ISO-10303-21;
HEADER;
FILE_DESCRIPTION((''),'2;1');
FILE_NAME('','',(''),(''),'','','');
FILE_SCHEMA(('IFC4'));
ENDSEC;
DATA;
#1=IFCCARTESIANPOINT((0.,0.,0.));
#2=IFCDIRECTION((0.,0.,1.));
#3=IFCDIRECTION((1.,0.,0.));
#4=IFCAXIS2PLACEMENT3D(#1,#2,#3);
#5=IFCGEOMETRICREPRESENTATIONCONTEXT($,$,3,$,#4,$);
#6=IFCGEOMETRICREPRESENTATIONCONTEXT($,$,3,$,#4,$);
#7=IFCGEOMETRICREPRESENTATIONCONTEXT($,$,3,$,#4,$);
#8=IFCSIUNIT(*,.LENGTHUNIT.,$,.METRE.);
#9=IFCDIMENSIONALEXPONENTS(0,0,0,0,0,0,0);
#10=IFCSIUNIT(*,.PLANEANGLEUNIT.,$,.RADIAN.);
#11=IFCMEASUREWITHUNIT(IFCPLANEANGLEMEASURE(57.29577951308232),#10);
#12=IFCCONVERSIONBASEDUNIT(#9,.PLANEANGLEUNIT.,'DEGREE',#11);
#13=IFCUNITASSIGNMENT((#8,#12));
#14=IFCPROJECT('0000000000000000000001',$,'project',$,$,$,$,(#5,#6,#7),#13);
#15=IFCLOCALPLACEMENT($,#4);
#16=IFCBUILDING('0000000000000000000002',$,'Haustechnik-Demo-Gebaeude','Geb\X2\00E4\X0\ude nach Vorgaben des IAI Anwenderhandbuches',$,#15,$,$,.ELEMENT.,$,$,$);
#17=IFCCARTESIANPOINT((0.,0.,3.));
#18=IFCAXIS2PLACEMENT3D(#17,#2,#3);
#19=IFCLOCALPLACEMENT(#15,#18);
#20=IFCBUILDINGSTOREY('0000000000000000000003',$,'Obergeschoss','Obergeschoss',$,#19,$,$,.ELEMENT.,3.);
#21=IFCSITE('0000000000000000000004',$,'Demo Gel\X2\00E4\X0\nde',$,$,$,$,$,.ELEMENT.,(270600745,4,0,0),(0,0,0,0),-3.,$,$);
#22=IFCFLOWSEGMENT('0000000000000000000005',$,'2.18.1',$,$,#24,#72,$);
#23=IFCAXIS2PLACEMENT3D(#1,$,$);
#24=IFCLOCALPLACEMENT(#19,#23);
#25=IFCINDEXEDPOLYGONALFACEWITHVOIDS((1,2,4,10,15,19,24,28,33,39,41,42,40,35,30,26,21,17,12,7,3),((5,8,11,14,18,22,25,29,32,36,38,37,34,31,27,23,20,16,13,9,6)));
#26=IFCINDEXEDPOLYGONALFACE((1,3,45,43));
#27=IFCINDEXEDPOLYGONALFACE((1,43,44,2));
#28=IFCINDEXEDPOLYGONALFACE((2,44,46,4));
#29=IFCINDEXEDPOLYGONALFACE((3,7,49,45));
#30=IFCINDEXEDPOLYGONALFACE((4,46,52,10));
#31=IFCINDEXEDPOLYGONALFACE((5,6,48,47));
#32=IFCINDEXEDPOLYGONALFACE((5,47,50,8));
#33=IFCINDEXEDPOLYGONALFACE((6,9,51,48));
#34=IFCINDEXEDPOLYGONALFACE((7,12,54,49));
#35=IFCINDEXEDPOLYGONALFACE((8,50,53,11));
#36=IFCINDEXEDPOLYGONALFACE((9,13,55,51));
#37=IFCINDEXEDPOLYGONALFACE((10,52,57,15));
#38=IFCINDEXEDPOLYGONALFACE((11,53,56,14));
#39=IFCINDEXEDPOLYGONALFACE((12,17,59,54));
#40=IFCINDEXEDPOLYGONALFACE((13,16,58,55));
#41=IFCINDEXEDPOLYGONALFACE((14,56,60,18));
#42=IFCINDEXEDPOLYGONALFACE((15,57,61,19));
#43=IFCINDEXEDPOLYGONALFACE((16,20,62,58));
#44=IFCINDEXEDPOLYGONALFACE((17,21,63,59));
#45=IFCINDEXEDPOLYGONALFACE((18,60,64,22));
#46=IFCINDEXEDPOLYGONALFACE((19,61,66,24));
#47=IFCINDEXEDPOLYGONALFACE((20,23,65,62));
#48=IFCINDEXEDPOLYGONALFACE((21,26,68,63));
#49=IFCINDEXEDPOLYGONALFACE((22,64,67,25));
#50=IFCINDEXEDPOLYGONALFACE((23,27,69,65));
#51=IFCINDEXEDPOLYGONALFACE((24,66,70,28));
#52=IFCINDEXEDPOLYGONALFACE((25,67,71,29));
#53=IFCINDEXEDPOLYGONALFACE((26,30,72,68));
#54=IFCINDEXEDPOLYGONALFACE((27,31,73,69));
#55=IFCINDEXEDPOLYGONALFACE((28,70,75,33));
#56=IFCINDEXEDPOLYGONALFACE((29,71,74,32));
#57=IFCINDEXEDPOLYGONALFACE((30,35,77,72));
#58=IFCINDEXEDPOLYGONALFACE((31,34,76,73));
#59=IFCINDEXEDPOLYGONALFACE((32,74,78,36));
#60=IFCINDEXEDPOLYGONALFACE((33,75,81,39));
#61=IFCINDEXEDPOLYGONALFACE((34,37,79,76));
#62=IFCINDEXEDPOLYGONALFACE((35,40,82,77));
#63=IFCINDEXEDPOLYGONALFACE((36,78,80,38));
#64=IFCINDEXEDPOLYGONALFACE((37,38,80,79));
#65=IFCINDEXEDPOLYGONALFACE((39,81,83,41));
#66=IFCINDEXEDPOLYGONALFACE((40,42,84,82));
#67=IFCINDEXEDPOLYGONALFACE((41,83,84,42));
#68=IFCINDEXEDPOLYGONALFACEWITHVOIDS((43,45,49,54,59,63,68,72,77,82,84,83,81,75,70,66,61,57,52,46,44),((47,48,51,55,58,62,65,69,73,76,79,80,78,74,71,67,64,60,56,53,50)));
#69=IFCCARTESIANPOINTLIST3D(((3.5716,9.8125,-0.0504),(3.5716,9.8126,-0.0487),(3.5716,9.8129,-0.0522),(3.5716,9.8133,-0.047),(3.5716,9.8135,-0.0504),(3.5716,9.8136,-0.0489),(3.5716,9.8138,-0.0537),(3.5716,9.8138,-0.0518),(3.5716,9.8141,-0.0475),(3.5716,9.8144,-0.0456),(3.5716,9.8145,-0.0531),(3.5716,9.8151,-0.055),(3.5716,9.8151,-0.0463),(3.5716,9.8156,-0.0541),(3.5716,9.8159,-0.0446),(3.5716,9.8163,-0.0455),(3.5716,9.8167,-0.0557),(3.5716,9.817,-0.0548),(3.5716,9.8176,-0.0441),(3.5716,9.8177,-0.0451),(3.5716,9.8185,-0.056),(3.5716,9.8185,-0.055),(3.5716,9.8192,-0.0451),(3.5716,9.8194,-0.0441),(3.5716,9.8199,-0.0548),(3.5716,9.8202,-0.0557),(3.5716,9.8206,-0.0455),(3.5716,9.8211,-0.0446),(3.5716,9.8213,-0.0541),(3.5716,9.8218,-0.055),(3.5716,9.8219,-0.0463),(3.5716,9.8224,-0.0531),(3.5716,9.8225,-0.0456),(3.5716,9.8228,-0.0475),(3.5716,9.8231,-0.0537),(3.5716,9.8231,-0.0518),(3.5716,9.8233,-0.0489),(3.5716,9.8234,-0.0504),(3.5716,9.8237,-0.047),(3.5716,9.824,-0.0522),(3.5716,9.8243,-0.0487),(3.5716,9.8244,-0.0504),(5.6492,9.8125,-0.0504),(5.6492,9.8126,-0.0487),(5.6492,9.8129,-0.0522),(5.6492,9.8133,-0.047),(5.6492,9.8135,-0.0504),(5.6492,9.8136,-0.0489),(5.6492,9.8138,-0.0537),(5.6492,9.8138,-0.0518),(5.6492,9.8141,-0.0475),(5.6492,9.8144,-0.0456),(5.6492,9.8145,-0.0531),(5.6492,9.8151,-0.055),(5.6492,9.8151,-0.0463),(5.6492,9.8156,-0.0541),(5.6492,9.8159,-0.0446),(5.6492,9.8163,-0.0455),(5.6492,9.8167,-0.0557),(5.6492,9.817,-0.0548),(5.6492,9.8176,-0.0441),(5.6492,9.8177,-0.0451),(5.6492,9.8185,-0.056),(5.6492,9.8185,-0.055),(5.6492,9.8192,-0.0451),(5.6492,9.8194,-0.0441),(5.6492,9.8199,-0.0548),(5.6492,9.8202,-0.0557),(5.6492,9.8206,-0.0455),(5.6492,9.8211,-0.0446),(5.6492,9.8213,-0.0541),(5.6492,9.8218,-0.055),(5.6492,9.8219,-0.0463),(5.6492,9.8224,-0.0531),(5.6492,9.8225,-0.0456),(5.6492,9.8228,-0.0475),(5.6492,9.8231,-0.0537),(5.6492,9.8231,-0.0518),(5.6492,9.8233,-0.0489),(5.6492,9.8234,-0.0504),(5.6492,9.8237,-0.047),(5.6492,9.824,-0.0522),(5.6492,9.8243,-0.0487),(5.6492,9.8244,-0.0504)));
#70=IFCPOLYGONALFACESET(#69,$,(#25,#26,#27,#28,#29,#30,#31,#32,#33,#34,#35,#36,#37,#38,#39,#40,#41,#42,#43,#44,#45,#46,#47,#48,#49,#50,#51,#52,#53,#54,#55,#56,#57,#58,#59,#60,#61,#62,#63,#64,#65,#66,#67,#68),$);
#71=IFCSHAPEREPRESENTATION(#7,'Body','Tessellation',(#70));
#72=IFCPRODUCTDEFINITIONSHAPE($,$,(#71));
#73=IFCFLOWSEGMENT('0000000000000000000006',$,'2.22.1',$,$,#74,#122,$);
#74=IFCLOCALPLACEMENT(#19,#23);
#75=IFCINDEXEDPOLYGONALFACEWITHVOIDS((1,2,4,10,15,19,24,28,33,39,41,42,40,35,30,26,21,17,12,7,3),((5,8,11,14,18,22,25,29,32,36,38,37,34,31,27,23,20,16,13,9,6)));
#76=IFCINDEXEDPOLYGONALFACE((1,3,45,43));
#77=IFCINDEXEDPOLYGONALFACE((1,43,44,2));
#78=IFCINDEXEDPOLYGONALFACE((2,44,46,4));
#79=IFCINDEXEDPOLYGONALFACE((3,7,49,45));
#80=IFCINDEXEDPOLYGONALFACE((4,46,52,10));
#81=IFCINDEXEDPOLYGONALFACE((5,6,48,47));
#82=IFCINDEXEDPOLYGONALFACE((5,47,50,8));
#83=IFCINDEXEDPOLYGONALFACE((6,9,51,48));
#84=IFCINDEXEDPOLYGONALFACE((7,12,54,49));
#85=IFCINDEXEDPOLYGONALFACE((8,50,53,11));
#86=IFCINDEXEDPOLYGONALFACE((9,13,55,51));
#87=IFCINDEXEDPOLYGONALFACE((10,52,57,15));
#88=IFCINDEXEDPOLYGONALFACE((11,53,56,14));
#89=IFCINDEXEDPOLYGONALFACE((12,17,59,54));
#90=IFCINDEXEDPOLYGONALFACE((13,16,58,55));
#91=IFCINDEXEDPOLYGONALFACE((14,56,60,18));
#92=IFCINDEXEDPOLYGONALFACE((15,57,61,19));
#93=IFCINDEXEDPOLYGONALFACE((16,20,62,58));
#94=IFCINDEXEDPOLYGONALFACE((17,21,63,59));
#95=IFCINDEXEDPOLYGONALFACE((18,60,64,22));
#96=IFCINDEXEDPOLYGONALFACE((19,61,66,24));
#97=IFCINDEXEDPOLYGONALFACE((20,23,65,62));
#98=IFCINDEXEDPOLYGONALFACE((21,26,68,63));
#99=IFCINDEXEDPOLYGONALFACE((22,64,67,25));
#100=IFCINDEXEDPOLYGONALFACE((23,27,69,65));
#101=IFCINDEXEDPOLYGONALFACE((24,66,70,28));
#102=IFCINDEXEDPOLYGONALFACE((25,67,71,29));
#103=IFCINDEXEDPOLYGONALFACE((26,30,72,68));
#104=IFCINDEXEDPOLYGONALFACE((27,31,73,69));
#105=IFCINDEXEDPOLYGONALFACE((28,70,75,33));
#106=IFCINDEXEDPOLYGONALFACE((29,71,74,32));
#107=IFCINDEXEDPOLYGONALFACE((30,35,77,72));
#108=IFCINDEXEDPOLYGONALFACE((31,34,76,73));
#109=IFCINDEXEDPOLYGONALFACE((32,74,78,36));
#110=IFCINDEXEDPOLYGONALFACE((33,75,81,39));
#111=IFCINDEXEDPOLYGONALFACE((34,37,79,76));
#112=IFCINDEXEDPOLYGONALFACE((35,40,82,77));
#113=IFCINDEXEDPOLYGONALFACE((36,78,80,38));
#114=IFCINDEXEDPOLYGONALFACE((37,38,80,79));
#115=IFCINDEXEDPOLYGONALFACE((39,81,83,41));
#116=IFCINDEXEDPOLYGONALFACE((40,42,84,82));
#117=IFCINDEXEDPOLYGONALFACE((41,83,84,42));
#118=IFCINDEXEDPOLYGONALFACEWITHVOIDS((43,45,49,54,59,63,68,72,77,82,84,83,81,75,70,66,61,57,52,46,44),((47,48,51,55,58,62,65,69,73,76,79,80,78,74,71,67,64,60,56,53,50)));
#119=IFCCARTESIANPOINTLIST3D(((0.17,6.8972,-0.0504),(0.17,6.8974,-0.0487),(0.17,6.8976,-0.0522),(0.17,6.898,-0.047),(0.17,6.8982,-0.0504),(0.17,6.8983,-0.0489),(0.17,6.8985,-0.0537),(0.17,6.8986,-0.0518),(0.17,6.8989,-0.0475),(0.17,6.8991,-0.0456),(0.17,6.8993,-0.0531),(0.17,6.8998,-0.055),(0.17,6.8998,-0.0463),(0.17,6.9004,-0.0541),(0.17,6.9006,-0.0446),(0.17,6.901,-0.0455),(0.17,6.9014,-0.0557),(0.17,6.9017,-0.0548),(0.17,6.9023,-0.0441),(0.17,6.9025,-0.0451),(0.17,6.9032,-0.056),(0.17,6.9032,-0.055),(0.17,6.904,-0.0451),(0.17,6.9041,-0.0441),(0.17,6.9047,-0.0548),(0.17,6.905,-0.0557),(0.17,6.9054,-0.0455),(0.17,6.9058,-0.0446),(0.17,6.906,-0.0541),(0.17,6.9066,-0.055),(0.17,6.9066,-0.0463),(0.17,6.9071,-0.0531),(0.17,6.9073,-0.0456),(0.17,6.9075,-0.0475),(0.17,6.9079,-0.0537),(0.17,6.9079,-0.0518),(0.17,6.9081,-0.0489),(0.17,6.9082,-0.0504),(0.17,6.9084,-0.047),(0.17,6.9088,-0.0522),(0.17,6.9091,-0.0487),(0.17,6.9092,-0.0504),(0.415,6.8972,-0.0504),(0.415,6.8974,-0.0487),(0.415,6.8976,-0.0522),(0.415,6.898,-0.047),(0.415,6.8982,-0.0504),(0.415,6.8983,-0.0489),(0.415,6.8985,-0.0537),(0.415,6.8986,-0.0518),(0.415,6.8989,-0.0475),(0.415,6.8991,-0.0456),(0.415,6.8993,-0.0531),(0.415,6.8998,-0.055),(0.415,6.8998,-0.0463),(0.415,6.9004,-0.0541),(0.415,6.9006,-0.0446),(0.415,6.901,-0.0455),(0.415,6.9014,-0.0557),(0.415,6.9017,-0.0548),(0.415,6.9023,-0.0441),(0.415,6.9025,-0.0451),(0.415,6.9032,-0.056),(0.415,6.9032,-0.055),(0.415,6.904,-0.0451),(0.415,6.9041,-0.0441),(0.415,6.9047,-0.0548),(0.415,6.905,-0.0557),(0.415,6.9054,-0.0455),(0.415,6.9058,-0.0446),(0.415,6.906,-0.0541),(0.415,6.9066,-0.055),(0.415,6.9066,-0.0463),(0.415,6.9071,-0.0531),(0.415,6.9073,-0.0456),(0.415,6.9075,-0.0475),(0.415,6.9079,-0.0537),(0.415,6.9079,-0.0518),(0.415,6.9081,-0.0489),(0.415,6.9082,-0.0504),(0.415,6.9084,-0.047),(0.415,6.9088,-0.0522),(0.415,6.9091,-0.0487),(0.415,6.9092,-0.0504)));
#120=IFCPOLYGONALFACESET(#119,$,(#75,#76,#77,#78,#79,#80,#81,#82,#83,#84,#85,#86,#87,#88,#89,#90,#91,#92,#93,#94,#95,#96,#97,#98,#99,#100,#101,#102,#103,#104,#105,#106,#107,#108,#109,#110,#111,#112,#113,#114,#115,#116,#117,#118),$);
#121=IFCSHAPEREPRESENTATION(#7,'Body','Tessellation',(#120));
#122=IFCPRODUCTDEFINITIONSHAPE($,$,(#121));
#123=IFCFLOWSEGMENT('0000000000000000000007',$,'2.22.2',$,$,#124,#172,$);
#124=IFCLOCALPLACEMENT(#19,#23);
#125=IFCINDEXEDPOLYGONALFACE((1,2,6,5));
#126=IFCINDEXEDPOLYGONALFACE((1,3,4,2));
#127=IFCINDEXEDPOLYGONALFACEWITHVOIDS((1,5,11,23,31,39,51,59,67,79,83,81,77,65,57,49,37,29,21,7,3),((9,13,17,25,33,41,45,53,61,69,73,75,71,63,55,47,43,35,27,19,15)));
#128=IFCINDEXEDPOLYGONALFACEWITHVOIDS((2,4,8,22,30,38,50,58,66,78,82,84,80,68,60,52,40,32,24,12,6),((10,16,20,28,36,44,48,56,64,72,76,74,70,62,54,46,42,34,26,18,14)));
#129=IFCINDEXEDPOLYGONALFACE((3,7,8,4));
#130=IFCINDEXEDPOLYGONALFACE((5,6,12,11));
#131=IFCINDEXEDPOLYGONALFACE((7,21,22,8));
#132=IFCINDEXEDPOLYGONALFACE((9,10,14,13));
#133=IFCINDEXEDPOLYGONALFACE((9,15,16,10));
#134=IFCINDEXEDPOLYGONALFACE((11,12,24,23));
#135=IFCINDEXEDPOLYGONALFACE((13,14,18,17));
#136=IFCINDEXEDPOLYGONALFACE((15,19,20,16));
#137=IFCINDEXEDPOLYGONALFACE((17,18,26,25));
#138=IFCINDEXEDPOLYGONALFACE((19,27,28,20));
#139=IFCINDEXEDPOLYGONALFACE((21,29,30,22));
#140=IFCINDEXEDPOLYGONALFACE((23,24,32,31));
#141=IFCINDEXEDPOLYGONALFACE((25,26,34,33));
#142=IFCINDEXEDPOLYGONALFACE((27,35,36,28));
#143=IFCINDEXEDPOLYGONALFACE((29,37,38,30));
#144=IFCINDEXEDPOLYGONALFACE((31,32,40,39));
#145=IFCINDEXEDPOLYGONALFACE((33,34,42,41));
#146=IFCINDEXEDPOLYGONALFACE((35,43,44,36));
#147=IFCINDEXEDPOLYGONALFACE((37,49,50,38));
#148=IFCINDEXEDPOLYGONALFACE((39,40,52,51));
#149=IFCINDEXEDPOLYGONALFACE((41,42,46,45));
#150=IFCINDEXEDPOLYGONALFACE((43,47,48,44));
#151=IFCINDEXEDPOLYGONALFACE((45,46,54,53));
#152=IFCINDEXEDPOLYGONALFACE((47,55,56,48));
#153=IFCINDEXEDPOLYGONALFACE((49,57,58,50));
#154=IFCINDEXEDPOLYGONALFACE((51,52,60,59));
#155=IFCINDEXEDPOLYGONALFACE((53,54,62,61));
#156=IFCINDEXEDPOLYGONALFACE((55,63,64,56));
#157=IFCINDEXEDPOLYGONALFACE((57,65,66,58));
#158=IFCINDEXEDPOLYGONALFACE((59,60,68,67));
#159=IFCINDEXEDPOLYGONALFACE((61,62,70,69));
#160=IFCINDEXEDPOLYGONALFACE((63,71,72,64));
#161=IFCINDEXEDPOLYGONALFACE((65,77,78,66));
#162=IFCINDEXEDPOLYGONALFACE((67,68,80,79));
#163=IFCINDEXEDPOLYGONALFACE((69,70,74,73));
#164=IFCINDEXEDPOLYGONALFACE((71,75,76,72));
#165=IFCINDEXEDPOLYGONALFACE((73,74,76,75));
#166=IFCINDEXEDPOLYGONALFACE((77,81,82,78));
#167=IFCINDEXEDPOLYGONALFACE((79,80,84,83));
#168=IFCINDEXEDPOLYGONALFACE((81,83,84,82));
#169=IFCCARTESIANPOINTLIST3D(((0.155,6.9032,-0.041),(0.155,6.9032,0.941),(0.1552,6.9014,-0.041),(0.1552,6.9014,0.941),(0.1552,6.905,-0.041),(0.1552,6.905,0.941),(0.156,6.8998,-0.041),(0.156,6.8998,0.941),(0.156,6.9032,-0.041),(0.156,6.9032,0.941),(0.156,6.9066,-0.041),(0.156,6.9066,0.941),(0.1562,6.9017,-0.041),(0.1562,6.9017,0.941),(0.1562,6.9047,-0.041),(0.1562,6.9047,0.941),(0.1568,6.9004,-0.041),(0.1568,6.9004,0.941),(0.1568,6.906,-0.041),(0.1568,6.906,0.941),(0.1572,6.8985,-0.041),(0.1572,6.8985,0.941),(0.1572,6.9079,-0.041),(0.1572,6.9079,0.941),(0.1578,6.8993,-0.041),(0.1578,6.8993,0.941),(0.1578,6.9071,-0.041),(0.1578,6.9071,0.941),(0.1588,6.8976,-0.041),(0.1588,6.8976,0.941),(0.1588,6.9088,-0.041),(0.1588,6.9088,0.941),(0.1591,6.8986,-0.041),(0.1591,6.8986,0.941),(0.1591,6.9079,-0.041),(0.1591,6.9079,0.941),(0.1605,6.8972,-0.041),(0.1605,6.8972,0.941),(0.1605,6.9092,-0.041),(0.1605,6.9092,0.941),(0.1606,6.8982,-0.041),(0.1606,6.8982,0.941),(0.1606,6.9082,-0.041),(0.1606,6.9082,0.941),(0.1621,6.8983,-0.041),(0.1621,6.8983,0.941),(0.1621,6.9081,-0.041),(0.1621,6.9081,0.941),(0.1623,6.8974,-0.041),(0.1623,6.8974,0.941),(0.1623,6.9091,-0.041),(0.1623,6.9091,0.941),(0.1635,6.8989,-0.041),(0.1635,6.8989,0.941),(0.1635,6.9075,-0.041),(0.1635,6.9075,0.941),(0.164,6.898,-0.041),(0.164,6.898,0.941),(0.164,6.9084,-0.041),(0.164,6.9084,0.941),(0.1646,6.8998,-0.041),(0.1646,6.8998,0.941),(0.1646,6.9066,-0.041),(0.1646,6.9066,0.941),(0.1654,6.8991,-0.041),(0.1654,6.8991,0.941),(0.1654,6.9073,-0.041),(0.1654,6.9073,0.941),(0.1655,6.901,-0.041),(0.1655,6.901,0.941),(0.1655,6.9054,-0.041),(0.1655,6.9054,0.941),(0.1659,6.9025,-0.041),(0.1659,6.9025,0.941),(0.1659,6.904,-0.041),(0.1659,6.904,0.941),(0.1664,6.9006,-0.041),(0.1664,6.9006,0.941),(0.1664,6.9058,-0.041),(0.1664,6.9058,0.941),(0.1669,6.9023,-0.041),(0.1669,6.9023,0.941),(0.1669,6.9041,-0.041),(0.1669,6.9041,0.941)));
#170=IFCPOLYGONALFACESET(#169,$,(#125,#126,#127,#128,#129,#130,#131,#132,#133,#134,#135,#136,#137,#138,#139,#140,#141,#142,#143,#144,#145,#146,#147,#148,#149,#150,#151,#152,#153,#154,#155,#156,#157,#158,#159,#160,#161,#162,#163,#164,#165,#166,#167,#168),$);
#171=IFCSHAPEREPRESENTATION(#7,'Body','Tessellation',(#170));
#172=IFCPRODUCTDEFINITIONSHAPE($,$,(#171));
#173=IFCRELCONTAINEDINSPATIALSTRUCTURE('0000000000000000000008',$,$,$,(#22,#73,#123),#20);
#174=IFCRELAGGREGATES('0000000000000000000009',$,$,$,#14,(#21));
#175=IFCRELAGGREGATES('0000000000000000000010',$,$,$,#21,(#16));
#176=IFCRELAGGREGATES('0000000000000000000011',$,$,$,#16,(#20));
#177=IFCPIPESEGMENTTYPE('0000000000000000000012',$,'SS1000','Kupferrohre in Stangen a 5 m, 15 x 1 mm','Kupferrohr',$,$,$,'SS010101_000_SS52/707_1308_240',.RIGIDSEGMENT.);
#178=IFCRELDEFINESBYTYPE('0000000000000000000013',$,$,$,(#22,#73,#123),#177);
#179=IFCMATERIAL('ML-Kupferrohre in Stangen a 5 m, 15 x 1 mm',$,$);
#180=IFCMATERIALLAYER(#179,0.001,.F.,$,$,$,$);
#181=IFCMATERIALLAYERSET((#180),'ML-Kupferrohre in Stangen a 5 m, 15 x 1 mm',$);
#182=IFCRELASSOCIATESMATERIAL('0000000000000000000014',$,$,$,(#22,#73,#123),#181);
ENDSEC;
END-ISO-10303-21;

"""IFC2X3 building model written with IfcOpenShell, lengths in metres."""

from ifc_helpers import new_model, entity, si_unit, converted_unit, frame, origin_with_axes, origin_2d_with_axis, place, context, project, spatial, hollow_circle, extrude, material, layer, layer_set, layer_usage, type_object, element, save


model = new_model("IFC2X3")

# Units and contexts
context_of_model_1 = context(None, 3, world=origin_with_axes())
context_of_model_2 = context(None, 3, world=origin_with_axes())
context_of_model_3 = context(None, 3, world=origin_with_axes())
ifc_project = project(units=[si_unit("LENGTHUNIT", "METRE"), converted_unit("PLANEANGLEUNIT", "DEGREE", entity("IfcPlaneAngleMeasure", 57.29577951308232), si_unit("PLANEANGLEUNIT", "RADIAN"), dimensions=[0, 0, 0, 0, 0, 0, 0])], contexts=[context_of_model_1, context_of_model_2, context_of_model_3])

# Site, building, storey
site = spatial("IfcSite", under=ifc_project, Name="Demo Gelände", CompositionType="ELEMENT", RefLatitude=(270600745, 4, 0, 0), RefLongitude=(0, 0, 0, 0), RefElevation=-3.0)
building_placement = place(None, origin_with_axes())
building = spatial("IfcBuilding", under=site, at=building_placement, Name="Haustechnik-Demo-Gebaeude", Description="Gebäude nach Vorgaben des IAI Anwenderhandbuches", CompositionType="ELEMENT")
storey_placement = place(building_placement, frame((0.0, 0.0, 3.0), z_axis=(0.0, 0.0, 1.0), x_axis=(1.0, 0.0, 0.0)))
storey = spatial("IfcBuildingStorey", under=building, at=storey_placement, Name="Obergeschoss", Description="Obergeschoss", CompositionType="ELEMENT", Elevation=3.0)

# Flow segments
ifc_material = material(Name="ML-Kupferrohre in Stangen a 5 m, 15 x 1 mm")
ifc_layer = layer(ifc_material, 0.001, ventilated=False)
ifc_layer_set = layer_set([ifc_layer], Name="ML-Kupferrohre in Stangen a 5 m, 15 x 1 mm")
ifc_layer_usage = layer_usage(ifc_layer_set, "AXIS2", "POSITIVE", 0.0)
pipe_segment_type_1 = type_object("IfcPipeSegmentType", Name="SS1000", Description="Kupferrohre in Stangen a 5 m, 15 x 1 mm", ApplicableOccurrence="Kupferrohr", ElementType="SS010101_000_SS52/707_1308_240", PredefinedType="RIGIDSEGMENT")
flow_segment_1_placement = place(storey_placement, frame((3.5716, 9.8185, -0.05), z_axis=(1.0, 0.0, 0.0), x_axis=(0.0, 0.0, -1.0)))
element("IfcFlowSegment", 1, at=flow_segment_1_placement, inside=storey, type_object=pipe_segment_type_1, material=ifc_layer_usage, Name="2.18.1", context=context_of_model_3, shape_type="SweptSolid", body=[
    extrude(hollow_circle(Radius=0.006, WallThickness=0.001, at=origin_2d_with_axis()), origin_with_axes(), (0.0, 0.0, 1.0), 2.0775),
])
flow_segment_2_placement = place(storey_placement, frame((0.415, 6.9032, -0.05), z_axis=(-1.0, 0.0, 0.0), x_axis=(0.0, 0.0, -1.0)))
element("IfcFlowSegment", 2, at=flow_segment_2_placement, inside=storey, type_object=pipe_segment_type_1, material=ifc_layer_usage, Name="2.22.1", context=context_of_model_3, shape_type="SweptSolid", body=[
    extrude(hollow_circle(Radius=0.006, WallThickness=0.001, at=origin_2d_with_axis()), origin_with_axes(), (0.0, 0.0, 1.0), 0.2451),
])
flow_segment_3_placement = place(storey_placement, frame((0.161, 6.9032, -0.041), z_axis=(0.0, 0.0, 1.0), x_axis=(-1.0, 0.0, 0.0)))
element("IfcFlowSegment", 3, at=flow_segment_3_placement, inside=storey, type_object=pipe_segment_type_1, material=ifc_layer_usage, Name="2.22.2", context=context_of_model_3, shape_type="SweptSolid", body=[
    extrude(hollow_circle(Radius=0.006, WallThickness=0.001, at=origin_2d_with_axis()), origin_with_axes(), (0.0, 0.0, 1.0), 0.982),
])

save(model, "model.ifc")
